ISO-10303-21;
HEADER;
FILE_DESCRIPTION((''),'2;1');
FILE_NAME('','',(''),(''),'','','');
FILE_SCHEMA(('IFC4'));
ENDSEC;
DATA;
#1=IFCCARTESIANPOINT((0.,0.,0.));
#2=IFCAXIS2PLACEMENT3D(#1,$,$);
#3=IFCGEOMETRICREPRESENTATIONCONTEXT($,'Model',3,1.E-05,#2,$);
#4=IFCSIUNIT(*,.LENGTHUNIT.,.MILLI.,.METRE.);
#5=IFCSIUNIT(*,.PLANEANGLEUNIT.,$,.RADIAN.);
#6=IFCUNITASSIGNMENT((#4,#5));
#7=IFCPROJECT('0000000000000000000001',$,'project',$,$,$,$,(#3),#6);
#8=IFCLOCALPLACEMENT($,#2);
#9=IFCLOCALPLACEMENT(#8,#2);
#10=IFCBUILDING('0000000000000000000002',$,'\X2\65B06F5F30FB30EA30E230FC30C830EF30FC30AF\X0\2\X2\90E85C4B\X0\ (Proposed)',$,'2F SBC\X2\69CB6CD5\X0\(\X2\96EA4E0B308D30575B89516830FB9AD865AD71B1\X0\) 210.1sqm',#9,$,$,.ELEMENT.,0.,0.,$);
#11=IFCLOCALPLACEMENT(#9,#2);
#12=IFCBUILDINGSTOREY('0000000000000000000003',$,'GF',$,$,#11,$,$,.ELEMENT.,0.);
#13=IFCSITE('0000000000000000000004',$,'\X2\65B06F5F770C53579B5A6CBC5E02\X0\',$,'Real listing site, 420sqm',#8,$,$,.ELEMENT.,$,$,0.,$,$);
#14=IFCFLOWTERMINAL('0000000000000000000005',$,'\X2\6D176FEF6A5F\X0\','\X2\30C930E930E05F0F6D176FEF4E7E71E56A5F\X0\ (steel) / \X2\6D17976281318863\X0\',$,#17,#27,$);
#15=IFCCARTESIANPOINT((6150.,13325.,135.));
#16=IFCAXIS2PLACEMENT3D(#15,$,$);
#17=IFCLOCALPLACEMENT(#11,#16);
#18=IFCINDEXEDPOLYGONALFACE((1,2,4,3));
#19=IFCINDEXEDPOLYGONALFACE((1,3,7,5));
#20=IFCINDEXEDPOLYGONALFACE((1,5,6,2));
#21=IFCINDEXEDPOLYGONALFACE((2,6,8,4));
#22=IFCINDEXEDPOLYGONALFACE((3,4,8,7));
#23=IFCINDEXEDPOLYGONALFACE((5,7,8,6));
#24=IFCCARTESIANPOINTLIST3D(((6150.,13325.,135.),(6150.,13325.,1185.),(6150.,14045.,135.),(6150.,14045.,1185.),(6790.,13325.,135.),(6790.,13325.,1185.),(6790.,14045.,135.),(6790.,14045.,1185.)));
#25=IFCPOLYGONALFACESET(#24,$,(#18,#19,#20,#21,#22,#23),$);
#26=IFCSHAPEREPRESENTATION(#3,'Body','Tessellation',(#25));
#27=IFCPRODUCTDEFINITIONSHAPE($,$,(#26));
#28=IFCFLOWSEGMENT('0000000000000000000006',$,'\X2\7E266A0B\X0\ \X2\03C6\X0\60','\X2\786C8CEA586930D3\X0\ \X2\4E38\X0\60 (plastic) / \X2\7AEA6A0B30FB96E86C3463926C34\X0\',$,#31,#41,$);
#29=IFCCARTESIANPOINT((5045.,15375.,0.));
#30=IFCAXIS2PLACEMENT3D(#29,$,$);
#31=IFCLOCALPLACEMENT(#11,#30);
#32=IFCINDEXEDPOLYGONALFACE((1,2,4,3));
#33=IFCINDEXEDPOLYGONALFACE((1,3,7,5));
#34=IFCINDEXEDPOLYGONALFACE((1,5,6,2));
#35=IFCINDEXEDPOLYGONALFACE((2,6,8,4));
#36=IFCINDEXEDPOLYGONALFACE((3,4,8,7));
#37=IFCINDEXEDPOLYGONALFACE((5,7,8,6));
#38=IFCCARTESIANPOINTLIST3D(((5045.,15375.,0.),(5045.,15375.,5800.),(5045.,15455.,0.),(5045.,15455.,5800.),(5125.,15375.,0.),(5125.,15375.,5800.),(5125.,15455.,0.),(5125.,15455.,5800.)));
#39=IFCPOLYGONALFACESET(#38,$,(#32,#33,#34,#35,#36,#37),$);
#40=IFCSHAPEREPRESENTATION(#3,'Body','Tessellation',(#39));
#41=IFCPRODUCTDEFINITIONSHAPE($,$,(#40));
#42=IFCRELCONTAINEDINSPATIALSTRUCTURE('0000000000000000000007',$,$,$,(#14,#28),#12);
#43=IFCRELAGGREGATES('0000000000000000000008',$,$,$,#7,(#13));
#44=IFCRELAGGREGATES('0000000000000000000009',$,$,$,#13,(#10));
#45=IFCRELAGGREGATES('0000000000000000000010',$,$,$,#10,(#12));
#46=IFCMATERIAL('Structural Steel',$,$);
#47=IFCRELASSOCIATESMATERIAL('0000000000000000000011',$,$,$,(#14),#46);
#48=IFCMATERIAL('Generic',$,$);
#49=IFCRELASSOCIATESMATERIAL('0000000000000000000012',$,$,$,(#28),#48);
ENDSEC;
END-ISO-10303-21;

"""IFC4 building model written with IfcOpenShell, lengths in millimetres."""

from ifc_helpers import new_model, si_unit, frame, frame_2d, origin, place, context, project, spatial, rectangle, extrude, material, element, save


model = new_model("IFC4")

# Units and contexts
model_context = context("Model", 3, precision=1e-05, world=origin())
ifc_project = project(units=[si_unit("LENGTHUNIT", "METRE", prefix="MILLI"), si_unit("PLANEANGLEUNIT", "RADIAN")], contexts=[model_context])

# Site, building, storey
site_placement = place(None, origin())
site = spatial("IfcSite", under=ifc_project, at=site_placement, Name="新潟県南魚沼市", ObjectType="Real listing site, 420sqm", CompositionType="ELEMENT", RefElevation=0.0)
building_placement = place(site_placement, origin())
building = spatial("IfcBuilding", under=site, at=building_placement, Name="新潟・リモートワーク2部屋 (Proposed)", ObjectType="2F SBC構法(雪下ろし安全・高断熱) 210.1sqm", CompositionType="ELEMENT", ElevationOfRefHeight=0.0, ElevationOfTerrain=0.0)
storey_placement = place(building_placement, origin())
storey = spatial("IfcBuildingStorey", under=building, at=storey_placement, Name="GF", CompositionType="ELEMENT", Elevation=0.0)

# Flow terminal
ifc_material_1 = material(Name="Structural Steel")
flow_terminal_placement = place(storey_placement, frame((6150.0, 13325.0, 135.0)))
element("IfcFlowTerminal", 1, at=flow_terminal_placement, inside=storey, material=ifc_material_1, Name="洗濯機", Description="ドラム式洗濯乾燥機 (steel) / 洗面脱衣", context=model_context, shape_type="SweptSolid", body=[
    extrude(rectangle(XDim=640.0, YDim=720.0, at=frame_2d((320.0, 360.0))), frame((6150.0, 13325.0, 135.0)), (0.0, 0.0, 1.0), 1050.0),
])

# Flow segment
ifc_material_2 = material(Name="Generic")
flow_segment_1_placement = place(storey_placement, frame((5045.0, 15375.0, 0.0)))
element("IfcFlowSegment", 2, at=flow_segment_1_placement, inside=storey, material=ifc_material_2, Name="縦樋 φ60", Description="硬質塩ビ 丸60 (plastic) / 竪樋・雨水排水", context=model_context, shape_type="SweptSolid", body=[
    extrude(rectangle(XDim=80.0, YDim=80.0, at=frame_2d((40.0, 40.0))), frame((5045.0, 15375.0, 0.0)), (0.0, 0.0, 1.0), 5800.0),
])

save(model, "model.ifc")
